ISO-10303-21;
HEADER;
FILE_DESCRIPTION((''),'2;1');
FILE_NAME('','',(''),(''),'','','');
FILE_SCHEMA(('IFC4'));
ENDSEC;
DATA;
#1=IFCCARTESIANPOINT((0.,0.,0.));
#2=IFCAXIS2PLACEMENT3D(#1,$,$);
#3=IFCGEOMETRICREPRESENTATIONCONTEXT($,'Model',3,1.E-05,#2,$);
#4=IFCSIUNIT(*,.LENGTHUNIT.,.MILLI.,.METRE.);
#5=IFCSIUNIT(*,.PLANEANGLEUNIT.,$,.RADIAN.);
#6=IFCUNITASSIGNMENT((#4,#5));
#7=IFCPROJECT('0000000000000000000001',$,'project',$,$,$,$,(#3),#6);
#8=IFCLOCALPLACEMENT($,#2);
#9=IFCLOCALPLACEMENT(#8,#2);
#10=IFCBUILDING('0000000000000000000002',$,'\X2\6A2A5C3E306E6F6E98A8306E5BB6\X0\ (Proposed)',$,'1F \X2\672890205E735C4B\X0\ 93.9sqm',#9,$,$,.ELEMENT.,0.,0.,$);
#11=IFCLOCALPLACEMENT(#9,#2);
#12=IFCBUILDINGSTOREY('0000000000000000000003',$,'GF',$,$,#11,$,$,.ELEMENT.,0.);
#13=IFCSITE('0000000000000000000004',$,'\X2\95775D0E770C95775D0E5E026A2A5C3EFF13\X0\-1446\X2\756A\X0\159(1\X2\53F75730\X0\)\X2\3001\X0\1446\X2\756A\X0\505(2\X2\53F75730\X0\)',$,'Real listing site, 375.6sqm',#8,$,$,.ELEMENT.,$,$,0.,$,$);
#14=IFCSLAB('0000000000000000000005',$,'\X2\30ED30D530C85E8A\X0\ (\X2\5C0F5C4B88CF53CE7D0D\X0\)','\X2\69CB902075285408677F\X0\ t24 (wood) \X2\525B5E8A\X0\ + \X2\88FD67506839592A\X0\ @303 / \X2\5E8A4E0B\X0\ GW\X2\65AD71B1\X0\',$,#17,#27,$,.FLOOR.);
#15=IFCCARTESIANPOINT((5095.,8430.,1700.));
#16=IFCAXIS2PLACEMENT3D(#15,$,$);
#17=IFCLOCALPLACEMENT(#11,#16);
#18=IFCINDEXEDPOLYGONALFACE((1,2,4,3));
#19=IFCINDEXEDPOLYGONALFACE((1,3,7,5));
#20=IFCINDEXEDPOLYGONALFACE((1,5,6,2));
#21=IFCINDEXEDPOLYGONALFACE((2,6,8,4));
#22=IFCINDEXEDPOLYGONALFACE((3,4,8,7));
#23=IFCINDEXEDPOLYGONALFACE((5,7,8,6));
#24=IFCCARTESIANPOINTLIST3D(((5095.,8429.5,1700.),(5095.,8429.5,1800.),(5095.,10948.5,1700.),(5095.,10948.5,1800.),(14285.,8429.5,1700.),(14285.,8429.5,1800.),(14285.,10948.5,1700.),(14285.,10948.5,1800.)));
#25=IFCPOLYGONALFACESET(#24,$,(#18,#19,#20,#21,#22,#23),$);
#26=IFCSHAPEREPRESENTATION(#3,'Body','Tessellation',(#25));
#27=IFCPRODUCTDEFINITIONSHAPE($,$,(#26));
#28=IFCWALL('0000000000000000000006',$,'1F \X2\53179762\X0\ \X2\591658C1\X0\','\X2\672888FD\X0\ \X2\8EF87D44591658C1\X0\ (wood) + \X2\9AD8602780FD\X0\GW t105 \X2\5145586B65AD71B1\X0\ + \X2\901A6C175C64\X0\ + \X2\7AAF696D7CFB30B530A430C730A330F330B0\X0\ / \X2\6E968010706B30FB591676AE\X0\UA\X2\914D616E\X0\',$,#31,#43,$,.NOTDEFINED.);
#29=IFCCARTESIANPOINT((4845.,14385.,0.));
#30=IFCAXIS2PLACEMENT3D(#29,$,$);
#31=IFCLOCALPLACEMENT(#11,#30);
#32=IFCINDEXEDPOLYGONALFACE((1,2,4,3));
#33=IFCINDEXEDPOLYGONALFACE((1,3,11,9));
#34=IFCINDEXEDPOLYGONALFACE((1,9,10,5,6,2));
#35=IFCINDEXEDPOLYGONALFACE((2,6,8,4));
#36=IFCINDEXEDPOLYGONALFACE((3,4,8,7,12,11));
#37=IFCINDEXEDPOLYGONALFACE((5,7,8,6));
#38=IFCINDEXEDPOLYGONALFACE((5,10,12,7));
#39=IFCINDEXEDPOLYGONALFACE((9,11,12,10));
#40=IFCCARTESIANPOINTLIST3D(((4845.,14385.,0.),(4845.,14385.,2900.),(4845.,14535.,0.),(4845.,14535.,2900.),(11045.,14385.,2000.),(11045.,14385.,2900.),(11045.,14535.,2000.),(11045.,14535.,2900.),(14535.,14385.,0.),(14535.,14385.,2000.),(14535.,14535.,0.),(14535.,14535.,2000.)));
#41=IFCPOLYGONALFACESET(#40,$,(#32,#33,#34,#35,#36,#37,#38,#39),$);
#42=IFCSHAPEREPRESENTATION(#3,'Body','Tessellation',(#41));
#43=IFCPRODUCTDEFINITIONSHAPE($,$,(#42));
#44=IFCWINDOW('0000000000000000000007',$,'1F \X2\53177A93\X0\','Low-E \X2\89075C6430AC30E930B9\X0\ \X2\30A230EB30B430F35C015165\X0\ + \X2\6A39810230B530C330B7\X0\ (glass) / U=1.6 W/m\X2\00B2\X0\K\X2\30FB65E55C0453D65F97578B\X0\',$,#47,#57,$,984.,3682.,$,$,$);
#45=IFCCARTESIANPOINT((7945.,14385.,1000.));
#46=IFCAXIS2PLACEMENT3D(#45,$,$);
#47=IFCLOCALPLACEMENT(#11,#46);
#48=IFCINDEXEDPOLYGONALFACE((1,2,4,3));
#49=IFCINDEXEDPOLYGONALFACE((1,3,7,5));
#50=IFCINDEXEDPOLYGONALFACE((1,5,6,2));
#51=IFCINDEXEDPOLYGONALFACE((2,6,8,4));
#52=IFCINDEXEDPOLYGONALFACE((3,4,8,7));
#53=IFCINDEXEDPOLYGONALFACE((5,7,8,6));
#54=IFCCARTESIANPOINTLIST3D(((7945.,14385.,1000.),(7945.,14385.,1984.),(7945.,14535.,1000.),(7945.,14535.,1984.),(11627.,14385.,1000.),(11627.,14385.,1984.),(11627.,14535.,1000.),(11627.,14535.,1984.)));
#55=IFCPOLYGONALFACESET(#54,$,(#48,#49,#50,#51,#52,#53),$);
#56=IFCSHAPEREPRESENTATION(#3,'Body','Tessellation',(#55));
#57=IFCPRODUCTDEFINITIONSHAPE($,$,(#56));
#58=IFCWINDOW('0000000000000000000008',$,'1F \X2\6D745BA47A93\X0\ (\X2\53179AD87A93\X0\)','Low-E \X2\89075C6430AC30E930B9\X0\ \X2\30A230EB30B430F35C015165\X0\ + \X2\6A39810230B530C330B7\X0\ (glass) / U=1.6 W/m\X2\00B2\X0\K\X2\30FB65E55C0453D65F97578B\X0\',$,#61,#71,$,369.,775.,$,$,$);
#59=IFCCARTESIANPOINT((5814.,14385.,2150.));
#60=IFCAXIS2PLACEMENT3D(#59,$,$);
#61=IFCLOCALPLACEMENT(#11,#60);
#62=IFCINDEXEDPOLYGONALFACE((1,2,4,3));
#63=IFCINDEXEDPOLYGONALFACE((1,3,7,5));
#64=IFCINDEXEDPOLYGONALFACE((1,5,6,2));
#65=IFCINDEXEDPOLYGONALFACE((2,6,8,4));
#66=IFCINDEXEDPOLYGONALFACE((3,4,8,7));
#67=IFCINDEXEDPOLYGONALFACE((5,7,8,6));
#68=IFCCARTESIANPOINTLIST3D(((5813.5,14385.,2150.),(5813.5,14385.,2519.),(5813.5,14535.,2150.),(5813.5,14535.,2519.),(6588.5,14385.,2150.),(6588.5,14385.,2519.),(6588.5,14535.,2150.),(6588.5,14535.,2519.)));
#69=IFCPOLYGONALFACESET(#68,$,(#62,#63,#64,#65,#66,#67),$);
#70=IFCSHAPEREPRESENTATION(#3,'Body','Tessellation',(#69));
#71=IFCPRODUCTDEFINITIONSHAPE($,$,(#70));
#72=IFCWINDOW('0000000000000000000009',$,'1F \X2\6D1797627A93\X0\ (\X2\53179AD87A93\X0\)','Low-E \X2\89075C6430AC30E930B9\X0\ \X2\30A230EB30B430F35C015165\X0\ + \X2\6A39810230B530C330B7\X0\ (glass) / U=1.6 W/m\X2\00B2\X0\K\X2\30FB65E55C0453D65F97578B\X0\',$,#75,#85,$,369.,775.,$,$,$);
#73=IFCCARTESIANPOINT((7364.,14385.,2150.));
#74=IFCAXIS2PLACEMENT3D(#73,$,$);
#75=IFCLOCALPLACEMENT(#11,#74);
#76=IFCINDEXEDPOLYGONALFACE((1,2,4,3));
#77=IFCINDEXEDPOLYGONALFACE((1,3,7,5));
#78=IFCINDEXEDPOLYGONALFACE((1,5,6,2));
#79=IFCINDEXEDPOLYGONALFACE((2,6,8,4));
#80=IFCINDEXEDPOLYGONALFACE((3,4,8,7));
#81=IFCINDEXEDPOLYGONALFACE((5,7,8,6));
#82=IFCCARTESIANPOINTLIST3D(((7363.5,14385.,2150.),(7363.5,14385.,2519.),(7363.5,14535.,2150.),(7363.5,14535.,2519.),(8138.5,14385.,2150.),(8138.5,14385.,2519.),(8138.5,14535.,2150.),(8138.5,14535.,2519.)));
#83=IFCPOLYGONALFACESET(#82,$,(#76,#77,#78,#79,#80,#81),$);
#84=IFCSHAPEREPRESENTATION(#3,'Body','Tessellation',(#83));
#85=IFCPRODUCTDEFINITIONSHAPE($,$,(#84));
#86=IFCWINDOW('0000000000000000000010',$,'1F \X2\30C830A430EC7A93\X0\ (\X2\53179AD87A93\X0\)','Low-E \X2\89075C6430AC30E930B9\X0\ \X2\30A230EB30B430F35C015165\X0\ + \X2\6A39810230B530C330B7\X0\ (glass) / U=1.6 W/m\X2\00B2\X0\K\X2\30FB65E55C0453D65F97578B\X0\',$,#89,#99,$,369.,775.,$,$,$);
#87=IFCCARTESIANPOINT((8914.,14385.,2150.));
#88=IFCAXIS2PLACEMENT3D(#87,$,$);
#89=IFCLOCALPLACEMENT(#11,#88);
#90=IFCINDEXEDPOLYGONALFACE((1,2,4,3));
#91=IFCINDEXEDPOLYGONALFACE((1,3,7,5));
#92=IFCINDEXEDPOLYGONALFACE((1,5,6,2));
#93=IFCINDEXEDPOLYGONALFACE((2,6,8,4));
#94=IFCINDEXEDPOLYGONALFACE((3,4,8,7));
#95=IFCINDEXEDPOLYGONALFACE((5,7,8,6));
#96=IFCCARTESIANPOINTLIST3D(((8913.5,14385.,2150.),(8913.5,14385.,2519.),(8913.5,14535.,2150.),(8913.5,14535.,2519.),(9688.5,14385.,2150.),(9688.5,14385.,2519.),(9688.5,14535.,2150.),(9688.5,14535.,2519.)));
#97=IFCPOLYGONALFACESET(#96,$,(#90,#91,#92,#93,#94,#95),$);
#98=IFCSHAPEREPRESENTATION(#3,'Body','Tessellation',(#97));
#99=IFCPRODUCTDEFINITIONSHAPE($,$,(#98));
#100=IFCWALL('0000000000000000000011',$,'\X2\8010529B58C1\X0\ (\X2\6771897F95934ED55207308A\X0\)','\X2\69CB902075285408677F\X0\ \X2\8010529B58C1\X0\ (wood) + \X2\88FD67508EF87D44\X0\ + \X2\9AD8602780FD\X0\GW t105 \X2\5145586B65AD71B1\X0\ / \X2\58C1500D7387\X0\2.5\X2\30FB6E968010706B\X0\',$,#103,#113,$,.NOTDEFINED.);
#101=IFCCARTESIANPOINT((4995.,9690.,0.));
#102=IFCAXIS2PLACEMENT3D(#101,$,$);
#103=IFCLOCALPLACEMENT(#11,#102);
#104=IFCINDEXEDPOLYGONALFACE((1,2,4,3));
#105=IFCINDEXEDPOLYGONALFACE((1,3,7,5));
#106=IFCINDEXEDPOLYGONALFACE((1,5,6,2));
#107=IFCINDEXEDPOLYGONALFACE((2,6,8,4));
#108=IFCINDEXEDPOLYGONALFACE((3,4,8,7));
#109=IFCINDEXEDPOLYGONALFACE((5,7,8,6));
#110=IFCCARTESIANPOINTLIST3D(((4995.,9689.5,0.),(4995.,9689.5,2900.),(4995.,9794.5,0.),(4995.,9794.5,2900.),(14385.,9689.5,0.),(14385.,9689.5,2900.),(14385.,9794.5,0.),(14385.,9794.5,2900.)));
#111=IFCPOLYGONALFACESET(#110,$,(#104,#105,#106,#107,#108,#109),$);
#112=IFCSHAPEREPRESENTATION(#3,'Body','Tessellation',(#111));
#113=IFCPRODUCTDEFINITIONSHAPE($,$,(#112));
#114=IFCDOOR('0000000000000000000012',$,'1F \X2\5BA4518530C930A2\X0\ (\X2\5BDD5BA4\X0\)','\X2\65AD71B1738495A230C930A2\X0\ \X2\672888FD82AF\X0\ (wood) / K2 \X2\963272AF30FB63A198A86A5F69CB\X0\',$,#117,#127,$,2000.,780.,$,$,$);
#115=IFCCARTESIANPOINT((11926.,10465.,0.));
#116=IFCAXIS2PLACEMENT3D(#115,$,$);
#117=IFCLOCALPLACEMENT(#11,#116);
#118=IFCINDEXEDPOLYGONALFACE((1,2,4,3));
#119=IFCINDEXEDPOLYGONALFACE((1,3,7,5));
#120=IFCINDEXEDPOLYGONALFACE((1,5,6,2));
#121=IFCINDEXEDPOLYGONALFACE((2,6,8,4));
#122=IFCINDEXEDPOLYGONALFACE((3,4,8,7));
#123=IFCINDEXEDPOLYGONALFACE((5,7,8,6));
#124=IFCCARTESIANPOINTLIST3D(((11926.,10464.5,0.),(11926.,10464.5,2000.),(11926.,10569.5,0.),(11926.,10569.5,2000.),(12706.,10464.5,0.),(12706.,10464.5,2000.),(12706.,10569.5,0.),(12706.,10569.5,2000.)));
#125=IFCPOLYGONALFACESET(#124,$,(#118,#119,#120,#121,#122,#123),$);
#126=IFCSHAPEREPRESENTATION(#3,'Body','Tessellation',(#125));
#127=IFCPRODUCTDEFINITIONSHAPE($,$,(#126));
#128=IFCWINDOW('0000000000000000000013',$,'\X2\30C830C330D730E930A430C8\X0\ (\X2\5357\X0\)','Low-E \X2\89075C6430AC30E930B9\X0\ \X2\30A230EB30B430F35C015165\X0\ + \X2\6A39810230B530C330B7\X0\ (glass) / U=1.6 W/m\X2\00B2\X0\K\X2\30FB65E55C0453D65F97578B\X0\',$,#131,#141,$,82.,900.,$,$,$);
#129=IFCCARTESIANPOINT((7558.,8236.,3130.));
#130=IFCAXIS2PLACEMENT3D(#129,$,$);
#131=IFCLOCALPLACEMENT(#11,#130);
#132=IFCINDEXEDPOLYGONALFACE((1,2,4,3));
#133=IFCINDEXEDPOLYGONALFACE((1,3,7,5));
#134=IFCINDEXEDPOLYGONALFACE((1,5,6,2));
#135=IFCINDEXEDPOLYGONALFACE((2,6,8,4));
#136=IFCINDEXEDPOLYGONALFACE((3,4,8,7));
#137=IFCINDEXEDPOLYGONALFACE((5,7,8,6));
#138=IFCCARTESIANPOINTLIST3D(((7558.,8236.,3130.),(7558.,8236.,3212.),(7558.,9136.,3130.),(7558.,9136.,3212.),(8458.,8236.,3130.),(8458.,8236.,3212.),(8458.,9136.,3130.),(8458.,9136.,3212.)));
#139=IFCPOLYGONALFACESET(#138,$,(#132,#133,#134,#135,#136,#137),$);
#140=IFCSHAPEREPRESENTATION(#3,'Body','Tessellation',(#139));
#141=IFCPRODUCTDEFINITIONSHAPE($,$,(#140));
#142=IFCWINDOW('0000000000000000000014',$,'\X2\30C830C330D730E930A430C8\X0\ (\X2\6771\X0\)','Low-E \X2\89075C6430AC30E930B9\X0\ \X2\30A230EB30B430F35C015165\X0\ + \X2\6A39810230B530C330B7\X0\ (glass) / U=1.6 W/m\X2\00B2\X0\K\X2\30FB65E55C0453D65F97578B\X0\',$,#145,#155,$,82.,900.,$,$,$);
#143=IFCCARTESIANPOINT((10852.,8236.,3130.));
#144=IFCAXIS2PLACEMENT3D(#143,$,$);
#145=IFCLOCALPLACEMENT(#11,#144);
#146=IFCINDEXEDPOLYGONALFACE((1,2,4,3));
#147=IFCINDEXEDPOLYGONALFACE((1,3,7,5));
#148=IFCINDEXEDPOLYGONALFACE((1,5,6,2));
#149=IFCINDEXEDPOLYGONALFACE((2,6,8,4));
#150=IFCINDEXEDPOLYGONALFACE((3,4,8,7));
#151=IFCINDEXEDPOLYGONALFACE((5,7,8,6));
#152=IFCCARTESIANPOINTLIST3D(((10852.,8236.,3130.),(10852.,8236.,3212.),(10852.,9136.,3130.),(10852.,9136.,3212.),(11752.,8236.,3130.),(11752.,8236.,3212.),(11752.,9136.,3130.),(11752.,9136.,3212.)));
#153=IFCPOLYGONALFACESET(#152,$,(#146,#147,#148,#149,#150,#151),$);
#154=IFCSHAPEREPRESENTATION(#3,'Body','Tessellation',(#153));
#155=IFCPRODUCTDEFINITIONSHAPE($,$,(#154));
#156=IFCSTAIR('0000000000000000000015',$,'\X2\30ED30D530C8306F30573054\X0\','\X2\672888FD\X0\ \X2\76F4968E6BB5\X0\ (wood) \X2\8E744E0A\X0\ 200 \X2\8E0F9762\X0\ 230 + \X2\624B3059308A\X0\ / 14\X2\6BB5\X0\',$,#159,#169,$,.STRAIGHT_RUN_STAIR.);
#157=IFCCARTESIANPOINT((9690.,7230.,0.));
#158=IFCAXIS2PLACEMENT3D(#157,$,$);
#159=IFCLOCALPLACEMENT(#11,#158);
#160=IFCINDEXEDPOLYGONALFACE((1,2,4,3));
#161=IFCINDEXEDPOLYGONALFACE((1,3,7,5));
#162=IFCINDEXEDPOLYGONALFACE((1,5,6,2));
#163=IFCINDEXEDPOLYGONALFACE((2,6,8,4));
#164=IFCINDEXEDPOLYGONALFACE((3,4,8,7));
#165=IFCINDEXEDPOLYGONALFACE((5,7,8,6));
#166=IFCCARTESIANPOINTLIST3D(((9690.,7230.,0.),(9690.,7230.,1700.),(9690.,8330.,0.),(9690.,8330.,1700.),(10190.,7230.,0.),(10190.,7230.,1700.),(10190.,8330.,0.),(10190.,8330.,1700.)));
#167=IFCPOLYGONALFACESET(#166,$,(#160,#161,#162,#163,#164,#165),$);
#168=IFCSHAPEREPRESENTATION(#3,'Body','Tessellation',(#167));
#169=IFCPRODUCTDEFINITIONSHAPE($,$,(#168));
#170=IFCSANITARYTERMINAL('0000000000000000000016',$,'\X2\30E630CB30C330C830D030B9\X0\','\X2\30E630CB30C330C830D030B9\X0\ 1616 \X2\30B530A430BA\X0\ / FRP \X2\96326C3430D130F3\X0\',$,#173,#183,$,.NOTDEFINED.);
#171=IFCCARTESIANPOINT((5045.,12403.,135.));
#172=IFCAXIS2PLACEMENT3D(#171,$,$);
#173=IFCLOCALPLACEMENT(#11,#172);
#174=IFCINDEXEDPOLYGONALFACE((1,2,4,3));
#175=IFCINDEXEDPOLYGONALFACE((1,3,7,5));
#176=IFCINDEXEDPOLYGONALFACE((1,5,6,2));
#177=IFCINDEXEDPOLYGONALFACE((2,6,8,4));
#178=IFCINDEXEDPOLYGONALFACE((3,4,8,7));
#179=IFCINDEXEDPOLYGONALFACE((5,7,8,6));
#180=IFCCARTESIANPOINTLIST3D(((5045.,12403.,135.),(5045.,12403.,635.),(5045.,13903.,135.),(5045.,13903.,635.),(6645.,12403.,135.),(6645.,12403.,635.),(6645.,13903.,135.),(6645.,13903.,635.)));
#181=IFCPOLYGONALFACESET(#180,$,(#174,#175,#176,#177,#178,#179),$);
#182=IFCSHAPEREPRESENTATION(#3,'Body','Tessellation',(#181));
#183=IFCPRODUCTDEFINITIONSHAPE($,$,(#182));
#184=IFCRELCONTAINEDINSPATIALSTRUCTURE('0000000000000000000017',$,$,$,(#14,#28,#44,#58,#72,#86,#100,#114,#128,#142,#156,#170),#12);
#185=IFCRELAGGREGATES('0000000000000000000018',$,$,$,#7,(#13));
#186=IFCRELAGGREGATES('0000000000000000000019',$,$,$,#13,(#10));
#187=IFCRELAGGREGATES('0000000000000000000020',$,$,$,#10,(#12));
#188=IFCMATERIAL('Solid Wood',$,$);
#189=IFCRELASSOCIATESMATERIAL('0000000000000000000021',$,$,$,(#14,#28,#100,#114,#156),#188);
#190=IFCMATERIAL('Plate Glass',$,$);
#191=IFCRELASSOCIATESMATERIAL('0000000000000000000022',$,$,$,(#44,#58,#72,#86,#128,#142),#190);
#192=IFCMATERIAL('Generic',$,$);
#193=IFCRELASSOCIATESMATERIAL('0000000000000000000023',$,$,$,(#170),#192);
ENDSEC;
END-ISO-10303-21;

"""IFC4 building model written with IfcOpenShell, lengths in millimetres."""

from ifc_helpers import new_model, si_unit, frame, frame_2d, origin, place, context, project, spatial, rectangle, extrude, material, element, fill, save


model = new_model("IFC4")

# Units and contexts
model_context = context("Model", 3, precision=1e-05, world=origin())
ifc_project = project(units=[si_unit("LENGTHUNIT", "METRE", prefix="MILLI"), si_unit("PLANEANGLEUNIT", "RADIAN")], contexts=[model_context])

# Site, building, storey
site_placement = place(None, origin())
site = spatial("IfcSite", under=ifc_project, at=site_placement, Name="長崎県長崎市横尾３-1446番159(1号地)、1446番505(2号地)", ObjectType="Real listing site, 375.6sqm", CompositionType="ELEMENT", RefElevation=0.0)
building_placement = place(site_placement, origin())
building = spatial("IfcBuilding", under=site, at=building_placement, Name="横尾の潮風の家 (Proposed)", ObjectType="1F 木造平屋 93.9sqm", CompositionType="ELEMENT", ElevationOfRefHeight=0.0, ElevationOfTerrain=0.0)
storey_placement = place(building_placement, origin())
storey = spatial("IfcBuildingStorey", under=building, at=storey_placement, Name="GF", CompositionType="ELEMENT", Elevation=0.0)

# Slab
ifc_material_1 = material(Name="Solid Wood")
slab_placement = place(storey_placement, frame((5095.0, 8430.0, 1700.0)))
element("IfcSlab", 1, at=slab_placement, inside=storey, material=ifc_material_1, Name="ロフト床 (小屋裏収納)", Description="構造用合板 t24 (wood) 剛床 + 製材根太 @303 / 床下 GW断熱", PredefinedType="FLOOR", context=model_context, shape_type="SweptSolid", body=[
    extrude(rectangle(XDim=9190.0, YDim=2519.0, at=frame_2d((4595.0, 1259.0))), frame((5095.0, 8430.0, 1700.0)), (0.0, 0.0, 1.0), 100.0),
])

# Wall, openings, windows
wall_1_placement = place(storey_placement, frame((4845.0, 14385.0, 0.0)))
wall_1 = element("IfcWall", 2, at=wall_1_placement, inside=storey, material=ifc_material_1, Name="1F 北面 外壁", Description="木製 軸組外壁 (wood) + 高性能GW t105 充填断熱 + 通気層 + 窯業系サイディング / 準耐火・外皮UA配慮", PredefinedType="NOTDEFINED", context=model_context, shape_type="SweptSolid", body=[
    extrude(rectangle(XDim=9690.0, YDim=150.0, at=frame_2d((4845.0, 75.0))), frame((4845.0, 14385.0, 0.0)), (0.0, 0.0, 1.0), 2900.0),
])
opening_1_placement = place(storey_placement, frame((7945.0, 14385.0, 1000.0)))
opening_1 = element("IfcOpeningElement", 3, at=opening_1_placement, cuts=wall_1, PredefinedType="NOTDEFINED", context=model_context, shape_type="SweptSolid", body=[
    extrude(rectangle(XDim=3682.0, YDim=150.0, at=frame_2d((1841.0, 75.0))), frame((7945.0, 14385.0, 1000.0)), (0.0, 0.0, 1.0), 984.0),
])
opening_2_placement = place(storey_placement, frame((5814.0, 14385.0, 2150.0)))
opening_2 = element("IfcOpeningElement", 4, at=opening_2_placement, cuts=wall_1, PredefinedType="NOTDEFINED", context=model_context, shape_type="SweptSolid", body=[
    extrude(rectangle(XDim=775.0, YDim=150.0, at=frame_2d((387.0, 75.0))), frame((5814.0, 14385.0, 2150.0)), (0.0, 0.0, 1.0), 369.0),
])
opening_3_placement = place(storey_placement, frame((7364.0, 14385.0, 2150.0)))
opening_3 = element("IfcOpeningElement", 5, at=opening_3_placement, cuts=wall_1, PredefinedType="NOTDEFINED", context=model_context, shape_type="SweptSolid", body=[
    extrude(rectangle(XDim=775.0, YDim=150.0, at=frame_2d((387.0, 75.0))), frame((7364.0, 14385.0, 2150.0)), (0.0, 0.0, 1.0), 369.0),
])
opening_4_placement = place(storey_placement, frame((8914.0, 14385.0, 2150.0)))
opening_4 = element("IfcOpeningElement", 6, at=opening_4_placement, cuts=wall_1, PredefinedType="NOTDEFINED", context=model_context, shape_type="SweptSolid", body=[
    extrude(rectangle(XDim=775.0, YDim=150.0, at=frame_2d((387.0, 75.0))), frame((8914.0, 14385.0, 2150.0)), (0.0, 0.0, 1.0), 369.0),
])
ifc_material_2 = material(Name="Plate Glass")
window_1_placement = place(storey_placement, frame((7945.0, 14385.0, 1000.0)))
window_1 = element("IfcWindow", 7, at=window_1_placement, inside=storey, material=ifc_material_2, Name="1F 北窓", Description="Low-E 複層ガラス アルゴン封入 + 樹脂サッシ (glass) / U=1.6 W/m²K・日射取得型", OverallHeight=984.0, OverallWidth=3682.0, context=model_context, shape_type="SweptSolid", body=[
    extrude(rectangle(XDim=3682.0, YDim=150.0, at=frame_2d((1841.0, 75.0))), frame((7945.0, 14385.0, 1000.0)), (0.0, 0.0, 1.0), 984.0),
])
fill(opening_1, window_1)
window_2_placement = place(storey_placement, frame((5814.0, 14385.0, 2150.0)))
window_2 = element("IfcWindow", 8, at=window_2_placement, inside=storey, material=ifc_material_2, Name="1F 浴室窓 (北高窓)", Description="Low-E 複層ガラス アルゴン封入 + 樹脂サッシ (glass) / U=1.6 W/m²K・日射取得型", OverallHeight=369.0, OverallWidth=775.0, context=model_context, shape_type="SweptSolid", body=[
    extrude(rectangle(XDim=775.0, YDim=150.0, at=frame_2d((387.0, 75.0))), frame((5814.0, 14385.0, 2150.0)), (0.0, 0.0, 1.0), 369.0),
])
fill(opening_2, window_2)
window_3_placement = place(storey_placement, frame((7364.0, 14385.0, 2150.0)))
window_3 = element("IfcWindow", 9, at=window_3_placement, inside=storey, material=ifc_material_2, Name="1F 洗面窓 (北高窓)", Description="Low-E 複層ガラス アルゴン封入 + 樹脂サッシ (glass) / U=1.6 W/m²K・日射取得型", OverallHeight=369.0, OverallWidth=775.0, context=model_context, shape_type="SweptSolid", body=[
    extrude(rectangle(XDim=775.0, YDim=150.0, at=frame_2d((387.0, 75.0))), frame((7364.0, 14385.0, 2150.0)), (0.0, 0.0, 1.0), 369.0),
])
fill(opening_3, window_3)
window_4_placement = place(storey_placement, frame((8914.0, 14385.0, 2150.0)))
window_4 = element("IfcWindow", 10, at=window_4_placement, inside=storey, material=ifc_material_2, Name="1F トイレ窓 (北高窓)", Description="Low-E 複層ガラス アルゴン封入 + 樹脂サッシ (glass) / U=1.6 W/m²K・日射取得型", OverallHeight=369.0, OverallWidth=775.0, context=model_context, shape_type="SweptSolid", body=[
    extrude(rectangle(XDim=775.0, YDim=150.0, at=frame_2d((387.0, 75.0))), frame((8914.0, 14385.0, 2150.0)), (0.0, 0.0, 1.0), 369.0),
])
fill(opening_4, window_4)

# Wall
wall_2_placement = place(storey_placement, frame((4995.0, 9690.0, 0.0)))
element("IfcWall", 11, at=wall_2_placement, inside=storey, material=ifc_material_1, Name="耐力壁 (東西間仕切り)", Description="構造用合板 耐力壁 (wood) + 製材軸組 + 高性能GW t105 充填断熱 / 壁倍率2.5・準耐火", PredefinedType="NOTDEFINED", context=model_context, shape_type="SweptSolid", body=[
    extrude(rectangle(XDim=9390.0, YDim=105.0, at=frame_2d((4695.0, 52.0))), frame((4995.0, 9690.0, 0.0)), (0.0, 0.0, 1.0), 2900.0),
])

# Door
door_1_placement = place(storey_placement, frame((11926.0, 10465.0, 0.0)))
element("IfcDoor", 12, at=door_1_placement, inside=storey, material=ifc_material_1, Name="1F 室内ドア (寝室)", Description="断熱玄関ドア 木製芯 (wood) / K2 防犯・採風機構", OverallHeight=2000.0, OverallWidth=780.0, context=model_context, shape_type="SweptSolid", body=[
    extrude(rectangle(XDim=780.0, YDim=105.0, at=frame_2d((390.0, 52.0))), frame((11926.0, 10465.0, 0.0)), (0.0, 0.0, 1.0), 2000.0),
])

# Windows
window_5_placement = place(storey_placement, frame((7558.0, 8236.0, 3130.0)))
element("IfcWindow", 13, at=window_5_placement, inside=storey, material=ifc_material_2, Name="トップライト (南)", Description="Low-E 複層ガラス アルゴン封入 + 樹脂サッシ (glass) / U=1.6 W/m²K・日射取得型", OverallHeight=82.0, OverallWidth=900.0, context=model_context, shape_type="SweptSolid", body=[
    extrude(rectangle(XDim=900.0, YDim=900.0, at=frame_2d((450.0, 450.0))), frame((7558.0, 8236.0, 3130.0)), (0.0, 0.0, 1.0), 82.0),
])
window_6_placement = place(storey_placement, frame((10852.0, 8236.0, 3130.0)))
element("IfcWindow", 14, at=window_6_placement, inside=storey, material=ifc_material_2, Name="トップライト (東)", Description="Low-E 複層ガラス アルゴン封入 + 樹脂サッシ (glass) / U=1.6 W/m²K・日射取得型", OverallHeight=82.0, OverallWidth=900.0, context=model_context, shape_type="SweptSolid", body=[
    extrude(rectangle(XDim=900.0, YDim=900.0, at=frame_2d((450.0, 450.0))), frame((10852.0, 8236.0, 3130.0)), (0.0, 0.0, 1.0), 82.0),
])

# Stair
stair_placement = place(storey_placement, frame((9690.0, 7230.0, 0.0)))
element("IfcStair", 15, at=stair_placement, inside=storey, material=ifc_material_1, Name="ロフトはしご", Description="木製 直階段 (wood) 蹴上 200 踏面 230 + 手すり / 14段", PredefinedType="STRAIGHT_RUN_STAIR", context=model_context, shape_type="SweptSolid", body=[
    extrude(rectangle(XDim=500.0, YDim=1100.0, at=frame_2d((250.0, 550.0))), frame((9690.0, 7230.0, 0.0)), (0.0, 0.0, 1.0), 1700.0),
])

# Sanitary terminal
ifc_material_3 = material(Name="Generic")
sanitary_terminal_1_placement = place(storey_placement, frame((5045.0, 12403.0, 135.0)))
element("IfcSanitaryTerminal", 16, at=sanitary_terminal_1_placement, inside=storey, material=ifc_material_3, Name="ユニットバス", Description="ユニットバス 1616 サイズ / FRP 防水パン", PredefinedType="NOTDEFINED", context=model_context, shape_type="SweptSolid", body=[
    extrude(rectangle(XDim=1600.0, YDim=1500.0, at=frame_2d((800.0, 750.0))), frame((5045.0, 12403.0, 135.0)), (0.0, 0.0, 1.0), 500.0),
])

save(model, "model.ifc")
